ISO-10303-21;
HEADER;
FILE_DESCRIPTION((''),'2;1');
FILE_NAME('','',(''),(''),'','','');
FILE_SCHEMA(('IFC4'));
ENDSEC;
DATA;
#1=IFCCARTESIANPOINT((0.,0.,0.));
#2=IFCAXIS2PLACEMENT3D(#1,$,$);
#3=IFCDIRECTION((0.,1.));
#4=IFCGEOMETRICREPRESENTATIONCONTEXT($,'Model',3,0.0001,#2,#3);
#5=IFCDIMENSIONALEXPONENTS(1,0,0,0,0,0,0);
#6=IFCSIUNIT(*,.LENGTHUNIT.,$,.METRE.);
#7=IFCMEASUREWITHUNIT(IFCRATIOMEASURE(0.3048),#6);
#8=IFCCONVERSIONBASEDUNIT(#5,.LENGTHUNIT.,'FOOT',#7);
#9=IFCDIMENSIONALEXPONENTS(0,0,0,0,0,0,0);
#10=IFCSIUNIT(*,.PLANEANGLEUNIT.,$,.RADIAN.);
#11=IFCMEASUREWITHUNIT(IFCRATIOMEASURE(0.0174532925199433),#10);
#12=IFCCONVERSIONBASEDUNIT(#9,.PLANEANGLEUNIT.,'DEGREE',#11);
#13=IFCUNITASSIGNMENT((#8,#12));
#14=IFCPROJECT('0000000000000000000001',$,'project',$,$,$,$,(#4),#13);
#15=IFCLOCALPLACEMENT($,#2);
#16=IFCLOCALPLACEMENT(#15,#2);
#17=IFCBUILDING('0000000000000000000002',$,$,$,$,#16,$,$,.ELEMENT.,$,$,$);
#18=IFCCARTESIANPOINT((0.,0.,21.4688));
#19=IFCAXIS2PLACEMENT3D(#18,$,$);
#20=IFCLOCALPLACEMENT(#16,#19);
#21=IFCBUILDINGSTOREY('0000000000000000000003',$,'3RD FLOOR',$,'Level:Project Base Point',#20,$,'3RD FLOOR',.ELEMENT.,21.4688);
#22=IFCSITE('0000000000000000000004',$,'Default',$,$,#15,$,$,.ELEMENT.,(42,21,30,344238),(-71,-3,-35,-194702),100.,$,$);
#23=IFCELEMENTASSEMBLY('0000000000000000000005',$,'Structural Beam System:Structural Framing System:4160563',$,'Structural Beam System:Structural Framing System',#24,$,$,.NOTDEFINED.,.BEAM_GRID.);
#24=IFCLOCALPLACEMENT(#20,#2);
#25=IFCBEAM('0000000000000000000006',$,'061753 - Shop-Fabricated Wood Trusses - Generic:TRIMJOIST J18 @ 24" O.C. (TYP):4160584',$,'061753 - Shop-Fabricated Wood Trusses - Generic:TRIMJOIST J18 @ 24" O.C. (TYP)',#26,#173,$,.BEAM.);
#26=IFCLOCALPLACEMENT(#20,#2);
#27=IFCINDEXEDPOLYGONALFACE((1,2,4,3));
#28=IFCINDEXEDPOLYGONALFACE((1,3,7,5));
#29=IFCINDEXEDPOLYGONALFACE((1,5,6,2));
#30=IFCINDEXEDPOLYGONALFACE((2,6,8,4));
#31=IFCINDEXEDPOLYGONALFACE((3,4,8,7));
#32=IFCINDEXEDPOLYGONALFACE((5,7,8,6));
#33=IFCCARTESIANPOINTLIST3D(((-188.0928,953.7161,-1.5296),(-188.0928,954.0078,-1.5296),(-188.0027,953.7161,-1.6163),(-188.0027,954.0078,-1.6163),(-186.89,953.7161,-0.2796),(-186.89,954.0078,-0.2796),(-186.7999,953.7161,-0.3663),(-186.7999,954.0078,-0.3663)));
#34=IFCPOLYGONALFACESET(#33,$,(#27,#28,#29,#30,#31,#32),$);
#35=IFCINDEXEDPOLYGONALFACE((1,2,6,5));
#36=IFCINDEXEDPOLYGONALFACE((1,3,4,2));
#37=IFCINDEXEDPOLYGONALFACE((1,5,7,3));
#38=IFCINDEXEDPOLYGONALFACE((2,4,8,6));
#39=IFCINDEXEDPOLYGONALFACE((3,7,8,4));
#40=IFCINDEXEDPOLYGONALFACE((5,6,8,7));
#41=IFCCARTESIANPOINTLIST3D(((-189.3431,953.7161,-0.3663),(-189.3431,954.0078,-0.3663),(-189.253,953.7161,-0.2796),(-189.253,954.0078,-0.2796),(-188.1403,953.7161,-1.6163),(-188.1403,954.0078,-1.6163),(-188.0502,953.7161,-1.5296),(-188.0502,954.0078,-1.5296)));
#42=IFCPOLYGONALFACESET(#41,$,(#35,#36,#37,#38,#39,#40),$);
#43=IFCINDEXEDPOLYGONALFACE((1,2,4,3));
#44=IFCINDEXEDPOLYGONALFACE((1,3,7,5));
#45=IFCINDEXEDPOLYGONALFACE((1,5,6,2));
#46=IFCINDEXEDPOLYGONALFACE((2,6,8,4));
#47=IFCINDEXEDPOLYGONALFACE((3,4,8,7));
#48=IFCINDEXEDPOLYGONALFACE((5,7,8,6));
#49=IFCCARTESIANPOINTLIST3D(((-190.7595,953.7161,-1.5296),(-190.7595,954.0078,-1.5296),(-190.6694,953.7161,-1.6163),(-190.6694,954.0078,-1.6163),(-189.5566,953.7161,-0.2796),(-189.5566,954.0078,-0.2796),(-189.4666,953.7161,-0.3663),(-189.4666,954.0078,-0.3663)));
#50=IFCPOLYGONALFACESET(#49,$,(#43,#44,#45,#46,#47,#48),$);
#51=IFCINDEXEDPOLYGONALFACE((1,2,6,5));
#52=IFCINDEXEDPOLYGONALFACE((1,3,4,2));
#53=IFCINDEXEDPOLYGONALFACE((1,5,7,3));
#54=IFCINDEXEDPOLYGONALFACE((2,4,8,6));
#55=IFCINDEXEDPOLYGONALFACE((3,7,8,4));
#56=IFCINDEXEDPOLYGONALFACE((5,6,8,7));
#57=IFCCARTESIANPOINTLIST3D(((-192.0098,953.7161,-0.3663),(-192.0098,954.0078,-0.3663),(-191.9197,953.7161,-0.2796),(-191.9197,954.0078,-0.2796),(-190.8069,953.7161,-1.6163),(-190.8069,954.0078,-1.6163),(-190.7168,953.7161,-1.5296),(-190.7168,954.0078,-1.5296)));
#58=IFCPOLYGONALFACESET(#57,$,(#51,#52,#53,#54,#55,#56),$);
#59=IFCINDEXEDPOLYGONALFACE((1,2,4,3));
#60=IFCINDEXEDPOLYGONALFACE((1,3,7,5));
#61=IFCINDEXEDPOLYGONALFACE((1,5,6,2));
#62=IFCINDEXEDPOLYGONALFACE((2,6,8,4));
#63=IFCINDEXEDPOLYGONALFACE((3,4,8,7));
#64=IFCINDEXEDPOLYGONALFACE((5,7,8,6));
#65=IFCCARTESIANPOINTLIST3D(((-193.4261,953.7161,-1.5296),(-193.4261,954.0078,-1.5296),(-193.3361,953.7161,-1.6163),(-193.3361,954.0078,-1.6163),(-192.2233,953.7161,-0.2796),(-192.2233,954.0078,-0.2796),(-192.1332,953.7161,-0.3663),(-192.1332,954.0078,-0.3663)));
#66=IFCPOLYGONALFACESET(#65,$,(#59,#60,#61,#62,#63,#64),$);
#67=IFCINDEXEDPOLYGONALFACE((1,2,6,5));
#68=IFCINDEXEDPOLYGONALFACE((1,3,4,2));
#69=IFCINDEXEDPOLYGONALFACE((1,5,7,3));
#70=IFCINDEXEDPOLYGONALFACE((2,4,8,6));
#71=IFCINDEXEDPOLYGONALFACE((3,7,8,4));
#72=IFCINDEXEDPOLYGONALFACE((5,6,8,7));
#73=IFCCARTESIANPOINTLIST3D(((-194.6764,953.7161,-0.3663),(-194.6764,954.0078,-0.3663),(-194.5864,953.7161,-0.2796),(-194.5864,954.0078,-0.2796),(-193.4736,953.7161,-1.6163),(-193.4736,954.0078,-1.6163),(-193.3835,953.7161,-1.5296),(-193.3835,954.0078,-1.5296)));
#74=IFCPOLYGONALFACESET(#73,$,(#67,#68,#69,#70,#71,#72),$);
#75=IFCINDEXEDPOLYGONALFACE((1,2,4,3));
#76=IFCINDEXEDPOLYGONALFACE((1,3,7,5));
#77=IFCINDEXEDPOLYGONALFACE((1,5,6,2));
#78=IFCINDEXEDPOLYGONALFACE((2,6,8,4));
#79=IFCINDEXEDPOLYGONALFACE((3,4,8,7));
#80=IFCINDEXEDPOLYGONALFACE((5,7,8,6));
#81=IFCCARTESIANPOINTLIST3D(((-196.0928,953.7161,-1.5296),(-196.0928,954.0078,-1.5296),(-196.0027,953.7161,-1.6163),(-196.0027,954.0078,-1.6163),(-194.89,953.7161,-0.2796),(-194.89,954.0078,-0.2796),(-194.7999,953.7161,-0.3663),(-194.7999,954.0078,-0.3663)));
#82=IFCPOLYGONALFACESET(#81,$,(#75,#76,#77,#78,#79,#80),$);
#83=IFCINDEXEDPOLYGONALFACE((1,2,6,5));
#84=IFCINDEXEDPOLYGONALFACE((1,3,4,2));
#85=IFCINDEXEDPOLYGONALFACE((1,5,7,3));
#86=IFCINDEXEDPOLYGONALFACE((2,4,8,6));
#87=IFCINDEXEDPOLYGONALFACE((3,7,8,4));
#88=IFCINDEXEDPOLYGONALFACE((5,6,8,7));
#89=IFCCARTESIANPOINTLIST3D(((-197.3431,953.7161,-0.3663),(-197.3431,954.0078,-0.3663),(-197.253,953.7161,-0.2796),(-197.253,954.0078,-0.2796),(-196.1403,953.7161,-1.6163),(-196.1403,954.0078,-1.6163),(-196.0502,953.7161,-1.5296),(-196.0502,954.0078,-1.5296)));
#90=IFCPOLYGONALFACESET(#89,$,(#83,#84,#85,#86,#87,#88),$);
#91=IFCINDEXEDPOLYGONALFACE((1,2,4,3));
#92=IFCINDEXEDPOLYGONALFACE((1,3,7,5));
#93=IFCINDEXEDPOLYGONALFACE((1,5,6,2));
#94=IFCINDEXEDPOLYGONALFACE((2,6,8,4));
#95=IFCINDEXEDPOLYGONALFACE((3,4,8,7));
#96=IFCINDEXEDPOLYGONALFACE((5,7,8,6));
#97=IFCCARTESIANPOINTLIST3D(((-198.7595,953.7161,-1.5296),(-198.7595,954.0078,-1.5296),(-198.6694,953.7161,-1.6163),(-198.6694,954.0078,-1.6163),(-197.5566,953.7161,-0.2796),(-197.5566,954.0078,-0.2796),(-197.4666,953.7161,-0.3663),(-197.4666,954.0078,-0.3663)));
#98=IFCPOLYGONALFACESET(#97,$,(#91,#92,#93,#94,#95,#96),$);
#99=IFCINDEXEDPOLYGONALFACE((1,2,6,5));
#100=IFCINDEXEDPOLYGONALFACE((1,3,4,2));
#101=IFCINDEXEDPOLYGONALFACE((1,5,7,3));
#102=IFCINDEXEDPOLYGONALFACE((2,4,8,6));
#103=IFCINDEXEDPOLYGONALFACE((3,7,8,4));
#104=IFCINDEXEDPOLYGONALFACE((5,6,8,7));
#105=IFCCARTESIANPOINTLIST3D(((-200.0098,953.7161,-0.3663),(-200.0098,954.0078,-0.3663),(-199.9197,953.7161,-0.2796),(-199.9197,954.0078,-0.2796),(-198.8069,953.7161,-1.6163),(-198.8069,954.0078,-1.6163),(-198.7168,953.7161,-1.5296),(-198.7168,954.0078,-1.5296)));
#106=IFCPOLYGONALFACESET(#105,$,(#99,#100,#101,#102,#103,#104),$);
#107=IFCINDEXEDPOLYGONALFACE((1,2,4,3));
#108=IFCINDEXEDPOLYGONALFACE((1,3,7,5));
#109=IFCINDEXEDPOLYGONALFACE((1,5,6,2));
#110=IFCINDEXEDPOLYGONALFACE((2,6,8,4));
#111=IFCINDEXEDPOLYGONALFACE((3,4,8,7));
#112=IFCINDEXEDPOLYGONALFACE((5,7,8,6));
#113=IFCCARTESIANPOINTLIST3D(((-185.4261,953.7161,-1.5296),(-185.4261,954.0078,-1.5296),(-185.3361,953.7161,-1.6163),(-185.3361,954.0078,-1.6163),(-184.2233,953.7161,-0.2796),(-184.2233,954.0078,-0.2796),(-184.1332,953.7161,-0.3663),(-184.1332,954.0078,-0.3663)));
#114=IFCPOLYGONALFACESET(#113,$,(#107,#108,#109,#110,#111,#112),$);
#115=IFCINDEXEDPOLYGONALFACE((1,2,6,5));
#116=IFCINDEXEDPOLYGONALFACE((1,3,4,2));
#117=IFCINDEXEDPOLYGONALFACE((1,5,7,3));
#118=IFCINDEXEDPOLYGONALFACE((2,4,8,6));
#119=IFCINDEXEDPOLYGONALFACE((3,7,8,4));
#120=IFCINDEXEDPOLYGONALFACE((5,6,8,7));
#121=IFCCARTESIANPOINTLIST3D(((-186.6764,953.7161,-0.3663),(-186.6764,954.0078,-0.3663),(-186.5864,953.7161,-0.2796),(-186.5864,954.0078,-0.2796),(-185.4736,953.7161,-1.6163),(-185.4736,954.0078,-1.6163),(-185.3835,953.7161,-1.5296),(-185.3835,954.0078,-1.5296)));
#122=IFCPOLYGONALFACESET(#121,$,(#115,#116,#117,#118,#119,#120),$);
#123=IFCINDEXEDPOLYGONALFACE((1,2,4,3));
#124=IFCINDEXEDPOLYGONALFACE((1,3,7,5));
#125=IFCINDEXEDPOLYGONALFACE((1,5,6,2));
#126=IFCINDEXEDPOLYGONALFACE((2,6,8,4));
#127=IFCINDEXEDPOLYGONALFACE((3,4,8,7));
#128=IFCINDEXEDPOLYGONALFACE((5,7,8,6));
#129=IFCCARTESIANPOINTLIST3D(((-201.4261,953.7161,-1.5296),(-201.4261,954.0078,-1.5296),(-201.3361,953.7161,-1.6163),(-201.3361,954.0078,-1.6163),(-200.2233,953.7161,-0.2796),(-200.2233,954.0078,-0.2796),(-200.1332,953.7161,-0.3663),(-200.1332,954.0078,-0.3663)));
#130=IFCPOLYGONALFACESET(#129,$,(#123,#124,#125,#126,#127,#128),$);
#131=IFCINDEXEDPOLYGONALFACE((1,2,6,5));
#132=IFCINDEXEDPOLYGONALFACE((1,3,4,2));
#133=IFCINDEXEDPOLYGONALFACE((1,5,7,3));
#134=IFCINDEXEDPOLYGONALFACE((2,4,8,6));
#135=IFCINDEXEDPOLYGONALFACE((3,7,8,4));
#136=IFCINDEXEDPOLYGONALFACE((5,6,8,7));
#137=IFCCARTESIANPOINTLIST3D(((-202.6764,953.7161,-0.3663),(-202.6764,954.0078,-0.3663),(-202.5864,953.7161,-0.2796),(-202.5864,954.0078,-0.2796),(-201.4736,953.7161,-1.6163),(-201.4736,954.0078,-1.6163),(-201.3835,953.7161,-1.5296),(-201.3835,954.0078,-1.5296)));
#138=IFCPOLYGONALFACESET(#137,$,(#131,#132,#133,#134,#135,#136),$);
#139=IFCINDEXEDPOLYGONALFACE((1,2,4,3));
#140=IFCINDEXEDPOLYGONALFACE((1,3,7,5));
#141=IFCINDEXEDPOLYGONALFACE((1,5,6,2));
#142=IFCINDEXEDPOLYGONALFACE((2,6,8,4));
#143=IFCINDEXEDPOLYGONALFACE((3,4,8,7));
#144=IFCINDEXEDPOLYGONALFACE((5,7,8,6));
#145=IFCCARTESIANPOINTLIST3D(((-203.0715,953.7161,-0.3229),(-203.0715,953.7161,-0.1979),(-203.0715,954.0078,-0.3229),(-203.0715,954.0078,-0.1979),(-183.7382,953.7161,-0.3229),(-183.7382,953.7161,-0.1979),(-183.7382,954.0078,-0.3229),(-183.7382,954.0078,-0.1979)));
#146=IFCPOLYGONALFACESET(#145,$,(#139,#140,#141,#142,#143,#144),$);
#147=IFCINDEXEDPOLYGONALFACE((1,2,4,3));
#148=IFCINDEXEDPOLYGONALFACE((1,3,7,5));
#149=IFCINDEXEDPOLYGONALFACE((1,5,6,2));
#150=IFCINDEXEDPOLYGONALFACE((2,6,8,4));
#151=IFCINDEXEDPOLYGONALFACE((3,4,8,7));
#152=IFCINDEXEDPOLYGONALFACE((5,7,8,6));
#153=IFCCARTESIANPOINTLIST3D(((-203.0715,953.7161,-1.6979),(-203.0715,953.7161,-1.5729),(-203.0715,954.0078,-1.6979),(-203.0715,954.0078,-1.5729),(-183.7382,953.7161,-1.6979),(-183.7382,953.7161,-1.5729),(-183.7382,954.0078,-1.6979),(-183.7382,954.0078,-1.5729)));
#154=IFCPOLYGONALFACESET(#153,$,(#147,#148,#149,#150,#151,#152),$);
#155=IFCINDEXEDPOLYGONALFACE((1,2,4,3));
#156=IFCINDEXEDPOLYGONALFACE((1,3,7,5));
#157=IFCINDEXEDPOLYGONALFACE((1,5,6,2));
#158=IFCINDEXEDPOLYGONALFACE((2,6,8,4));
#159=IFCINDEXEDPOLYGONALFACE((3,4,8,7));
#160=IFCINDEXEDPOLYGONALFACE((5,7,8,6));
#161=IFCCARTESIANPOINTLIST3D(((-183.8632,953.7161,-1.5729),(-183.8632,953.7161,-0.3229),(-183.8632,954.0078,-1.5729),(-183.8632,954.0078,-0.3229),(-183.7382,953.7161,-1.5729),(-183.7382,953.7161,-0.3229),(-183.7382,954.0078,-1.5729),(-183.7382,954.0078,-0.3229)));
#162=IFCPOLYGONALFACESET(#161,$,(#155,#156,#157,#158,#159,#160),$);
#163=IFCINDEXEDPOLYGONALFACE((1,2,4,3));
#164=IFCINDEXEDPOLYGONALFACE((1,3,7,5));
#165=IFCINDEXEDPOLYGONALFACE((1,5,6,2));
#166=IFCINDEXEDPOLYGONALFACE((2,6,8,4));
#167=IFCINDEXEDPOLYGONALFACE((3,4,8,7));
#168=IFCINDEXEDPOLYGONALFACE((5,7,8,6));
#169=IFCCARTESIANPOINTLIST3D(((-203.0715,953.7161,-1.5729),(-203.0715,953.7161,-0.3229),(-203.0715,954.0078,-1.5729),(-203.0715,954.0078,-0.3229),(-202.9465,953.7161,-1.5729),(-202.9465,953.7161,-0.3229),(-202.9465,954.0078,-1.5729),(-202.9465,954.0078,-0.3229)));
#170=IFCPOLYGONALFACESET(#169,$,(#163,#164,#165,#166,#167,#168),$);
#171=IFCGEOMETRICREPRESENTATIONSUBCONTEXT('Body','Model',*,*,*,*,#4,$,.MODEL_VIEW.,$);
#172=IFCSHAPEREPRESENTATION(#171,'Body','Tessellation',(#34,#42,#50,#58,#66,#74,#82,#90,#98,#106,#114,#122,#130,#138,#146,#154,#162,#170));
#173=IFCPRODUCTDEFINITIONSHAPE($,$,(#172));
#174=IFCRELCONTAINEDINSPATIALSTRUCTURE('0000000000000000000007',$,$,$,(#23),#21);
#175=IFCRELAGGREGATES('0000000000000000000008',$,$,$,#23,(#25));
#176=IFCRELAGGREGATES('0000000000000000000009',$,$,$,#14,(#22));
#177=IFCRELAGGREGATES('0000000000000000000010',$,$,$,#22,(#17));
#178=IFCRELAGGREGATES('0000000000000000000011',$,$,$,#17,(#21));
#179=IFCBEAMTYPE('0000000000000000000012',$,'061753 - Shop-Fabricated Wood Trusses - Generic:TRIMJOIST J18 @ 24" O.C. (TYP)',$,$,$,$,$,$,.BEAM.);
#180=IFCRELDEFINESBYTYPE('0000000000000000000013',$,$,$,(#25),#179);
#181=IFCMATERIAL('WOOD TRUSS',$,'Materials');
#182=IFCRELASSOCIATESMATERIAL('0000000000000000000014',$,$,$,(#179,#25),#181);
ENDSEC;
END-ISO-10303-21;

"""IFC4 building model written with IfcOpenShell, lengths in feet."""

from ifc_helpers import new_model, entity, si_unit, converted_unit, direction, frame, frame_2d, origin, origin_2d_with_axis, place, context, subcontext, project, spatial, rectangle, extrude, source, transform, mapped, material, material_profile, profile_set, profile_usage, type_object, type_shapes, element, aggregate, save


model = new_model("IFC4")

# Units and contexts
model_context = context("Model", 3, precision=0.0001, world=origin(), true_north=direction((0.0, 1.0)))
body_context = subcontext(model_context, "Body", "Model", "MODEL_VIEW")
ifc_project = project(units=[converted_unit("LENGTHUNIT", "FOOT", entity("IfcRatioMeasure", 0.3048), si_unit("LENGTHUNIT", "METRE"), dimensions=[1, 0, 0, 0, 0, 0, 0]), converted_unit("PLANEANGLEUNIT", "DEGREE", entity("IfcRatioMeasure", 0.0174532925199433), si_unit("PLANEANGLEUNIT", "RADIAN"), dimensions=[0, 0, 0, 0, 0, 0, 0])], contexts=[model_context])

# Site, building, storey
site_placement = place(None, origin())
site = spatial("IfcSite", under=ifc_project, at=site_placement, Name="Default", CompositionType="ELEMENT", RefLatitude=(42, 21, 30, 344238), RefLongitude=(-71, -3, -35, -194702), RefElevation=100.0)
building_placement = place(site_placement, origin())
building = spatial("IfcBuilding", under=site, at=building_placement, CompositionType="ELEMENT")
storey_placement = place(building_placement, frame((0.0, 0.0, 21.4688)))
storey = spatial("IfcBuildingStorey", under=building, at=storey_placement, Name="3RD FLOOR", ObjectType="Level:Project Base Point", LongName="3RD FLOOR", CompositionType="ELEMENT", Elevation=21.4688)

# Shared definitions
ifc_material_1 = material(Name="WOOD TRUSS", Category="Materials")
ifc_material_profile_1 = material_profile(ifc_material_1, rectangle(XDim=1.7347, YDim=0.125, at=frame_2d((0.0, 0.0), x_axis=(1.0, 0.0))), Name="TRIMJOIST J18 @ 24\" O.C. (TYP)")
ifc_material_profile_2 = material_profile(ifc_material_1, rectangle(XDim=1.7347, YDim=0.125, at=frame_2d((0.0, 0.0), x_axis=(1.0, 0.0))), Name="TRIMJOIST J18 @ 24\" O.C. (TYP)")
ifc_material_profile_3 = material_profile(ifc_material_1, rectangle(XDim=1.7347, YDim=0.125, at=frame_2d((0.0, 0.0), x_axis=(1.0, 0.0))), Name="TRIMJOIST J18 @ 24\" O.C. (TYP)")
ifc_material_profile_4 = material_profile(ifc_material_1, rectangle(XDim=1.7347, YDim=0.125, at=frame_2d((0.0, 0.0), x_axis=(1.0, 0.0))), Name="TRIMJOIST J18 @ 24\" O.C. (TYP)")
ifc_material_profile_5 = material_profile(ifc_material_1, rectangle(XDim=1.7347, YDim=0.125, at=frame_2d((0.0, 0.0), x_axis=(1.0, 0.0))), Name="TRIMJOIST J18 @ 24\" O.C. (TYP)")
ifc_material_profile_6 = material_profile(ifc_material_1, rectangle(XDim=1.7347, YDim=0.125, at=frame_2d((0.0, 0.0), x_axis=(1.0, 0.0))), Name="TRIMJOIST J18 @ 24\" O.C. (TYP)")
ifc_material_profile_7 = material_profile(ifc_material_1, rectangle(XDim=1.7347, YDim=0.125, at=frame_2d((0.0, 0.0), x_axis=(1.0, 0.0))), Name="TRIMJOIST J18 @ 24\" O.C. (TYP)")
ifc_material_profile_8 = material_profile(ifc_material_1, rectangle(XDim=1.7347, YDim=0.125, at=frame_2d((0.0, 0.0), x_axis=(1.0, 0.0))), Name="TRIMJOIST J18 @ 24\" O.C. (TYP)")
ifc_material_profile_9 = material_profile(ifc_material_1, rectangle(XDim=1.7347, YDim=0.125, at=frame_2d((0.0, 0.0), x_axis=(1.0, 0.0))), Name="TRIMJOIST J18 @ 24\" O.C. (TYP)")
ifc_material_profile_10 = material_profile(ifc_material_1, rectangle(XDim=1.7347, YDim=0.125, at=origin_2d_with_axis()), Name="TRIMJOIST J18 @ 24\" O.C. (TYP)")
ifc_material_profile_11 = material_profile(ifc_material_1, rectangle(XDim=0.125, YDim=0.2917, at=origin_2d_with_axis()), Name="TRIMJOIST J18 @ 24\" O.C. (TYP)")
ifc_material_profile_12 = material_profile(ifc_material_1, rectangle(XDim=0.125, YDim=0.2917, at=origin_2d_with_axis()), Name="TRIMJOIST J18 @ 24\" O.C. (TYP)")
ifc_material_profile_13 = material_profile(ifc_material_1, rectangle(XDim=1.25, YDim=0.2917, at=origin_2d_with_axis()), Name="TRIMJOIST J18 @ 24\" O.C. (TYP)")
ifc_material_profile_14 = material_profile(ifc_material_1, rectangle(XDim=1.25, YDim=0.2917, at=origin_2d_with_axis()), Name="TRIMJOIST J18 @ 24\" O.C. (TYP)")
ifc_profile_set_1 = profile_set([ifc_material_profile_1, ifc_material_profile_2, ifc_material_profile_3, ifc_material_profile_4, ifc_material_profile_5, ifc_material_profile_6, ifc_material_profile_7, ifc_material_profile_8, ifc_material_profile_9, ifc_material_profile_10, ifc_material_profile_11, ifc_material_profile_12, ifc_material_profile_13, ifc_material_profile_14], Name="TRIMJOIST J18 @ 24\" O.C. (TYP)")

# Element assembly, beam
assembly_1_placement = place(storey_placement, origin())
assembly_1 = element("IfcElementAssembly", 1, at=assembly_1_placement, inside=storey, Name="Structural Beam System:Structural Framing System:4160563", ObjectType="Structural Beam System:Structural Framing System", AssemblyPlace="NOTDEFINED", PredefinedType="BEAM_GRID")
ifc_profile_usage_1 = profile_usage(ifc_profile_set_1, cardinal=8)
beam_type_1 = type_object("IfcBeamType", Name="061753 - Shop-Fabricated Wood Trusses - Generic:TRIMJOIST J18 @ 24\" O.C. (TYP)", PredefinedType="BEAM", material=ifc_profile_set_1)
shared_shape_1 = source(origin(), body_context, "Body", "SweptSolid", [
    extrude(rectangle(XDim=1.7347, YDim=0.125, at=frame_2d((0.0, 0.0), x_axis=(1.0, 0.0))), frame((5.9585, -0.1458, 0.0), z_axis=(0.0, 1.0, 0.0), x_axis=(0.693383, 0.0, 0.720569)), (0.0, 0.0, 1.0), 0.2917),
    extrude(rectangle(XDim=1.7347, YDim=0.125, at=origin_2d_with_axis()), frame((4.7082, -0.1458, 0.0), z_axis=(0.0, 1.0, 0.0), x_axis=(0.693383, 0.0, -0.720569)), (0.0, 0.0, 1.0), 0.2917),
    extrude(rectangle(XDim=1.7347, YDim=0.125, at=frame_2d((0.0, 0.0), x_axis=(1.0, 0.0))), frame((3.2918, -0.1458, 0.0), z_axis=(0.0, 1.0, 0.0), x_axis=(0.693383, 0.0, 0.720569)), (0.0, 0.0, 1.0), 0.2917),
    extrude(rectangle(XDim=1.7347, YDim=0.125, at=frame_2d((0.0, 0.0), x_axis=(1.0, 0.0))), frame((2.0415, -0.1458, 0.0), z_axis=(0.0, 1.0, 0.0), x_axis=(0.693383, 0.0, -0.720569)), (0.0, 0.0, 1.0), 0.2917),
    extrude(rectangle(XDim=1.7347, YDim=0.125, at=frame_2d((0.0, 0.0), x_axis=(1.0, 0.0))), frame((0.6251, -0.1458, 0.0), z_axis=(0.0, 1.0, 0.0), x_axis=(0.693383, 0.0, 0.720569)), (0.0, 0.0, 1.0), 0.2917),
    extrude(rectangle(XDim=1.7347, YDim=0.125, at=frame_2d((0.0, 0.0), x_axis=(1.0, 0.0))), frame((-0.6251, -0.1458, 0.0), z_axis=(0.0, 1.0, 0.0), x_axis=(0.693383, 0.0, -0.720569)), (0.0, 0.0, 1.0), 0.2917),
    extrude(rectangle(XDim=1.7347, YDim=0.125, at=frame_2d((0.0, 0.0), x_axis=(1.0, 0.0))), frame((-2.0415, -0.1458, 0.0), z_axis=(0.0, 1.0, 0.0), x_axis=(0.693383, 0.0, 0.720569)), (0.0, 0.0, 1.0), 0.2917),
    extrude(rectangle(XDim=1.7347, YDim=0.125, at=origin_2d_with_axis()), frame((-3.2918, -0.1458, 0.0), z_axis=(0.0, 1.0, 0.0), x_axis=(0.693383, 0.0, -0.720569)), (0.0, 0.0, 1.0), 0.2917),
    extrude(rectangle(XDim=1.7347, YDim=0.125, at=frame_2d((0.0, 0.0), x_axis=(1.0, 0.0))), frame((-4.7082, -0.1458, 0.0), z_axis=(0.0, 1.0, 0.0), x_axis=(0.693383, 0.0, 0.720569)), (0.0, 0.0, 1.0), 0.2917),
    extrude(rectangle(XDim=1.7347, YDim=0.125, at=frame_2d((0.0, 0.0), x_axis=(1.0, 0.0))), frame((-5.9585, -0.1458, 0.0), z_axis=(0.0, 1.0, 0.0), x_axis=(0.693383, 0.0, -0.720569)), (0.0, 0.0, 1.0), 0.2917),
    extrude(rectangle(XDim=1.7347, YDim=0.125, at=frame_2d((0.0, 0.0), x_axis=(1.0, 0.0))), frame((8.6251, -0.1458, 0.0), z_axis=(0.0, 1.0, 0.0), x_axis=(0.693383, 0.0, 0.720569)), (0.0, 0.0, 1.0), 0.2917),
    extrude(rectangle(XDim=1.7347, YDim=0.125, at=origin_2d_with_axis()), frame((7.3749, -0.1458, 0.0), z_axis=(0.0, 1.0, 0.0), x_axis=(0.693383, 0.0, -0.720569)), (0.0, 0.0, 1.0), 0.2917),
    extrude(rectangle(XDim=1.7347, YDim=0.125, at=frame_2d((0.0, 0.0), x_axis=(1.0, 0.0))), frame((-7.3749, -0.1458, 0.0), z_axis=(0.0, 1.0, 0.0), x_axis=(0.693383, 0.0, 0.720569)), (0.0, 0.0, 1.0), 0.2917),
    extrude(rectangle(XDim=1.7347, YDim=0.125, at=origin_2d_with_axis()), frame((-8.6251, -0.1458, 0.0), z_axis=(0.0, 1.0, 0.0), x_axis=(0.693383, 0.0, -0.720569)), (0.0, 0.0, 1.0), 0.2917),
    extrude(rectangle(XDim=0.125, YDim=0.2917, at=origin_2d_with_axis()), frame((-9.6667, 0.0, 0.6875), z_axis=(1.0, 0.0, 0.0), x_axis=(0.0, 0.0, -1.0)), (0.0, 0.0, 1.0), 19.3333),
    extrude(rectangle(XDim=0.125, YDim=0.2917, at=origin_2d_with_axis()), frame((-9.6667, 0.0, -0.6875), z_axis=(1.0, 0.0, 0.0), x_axis=(0.0, 0.0, -1.0)), (0.0, 0.0, 1.0), 19.3333),
    extrude(rectangle(XDim=1.25, YDim=0.2917, at=origin_2d_with_axis()), frame((9.5417, 0.0, 0.0), z_axis=(1.0, 0.0, 0.0), x_axis=(0.0, 0.0, -1.0)), (0.0, 0.0, 1.0), 0.125),
    extrude(rectangle(XDim=1.25, YDim=0.2917, at=origin_2d_with_axis()), frame((-9.6667, 0.0, 0.0), z_axis=(1.0, 0.0, 0.0), x_axis=(0.0, 0.0, -1.0)), (0.0, 0.0, 1.0), 0.125),
])
type_shapes(beam_type_1, [shared_shape_1])
beam_1_placement = place(assembly_1_placement, frame((-193.4048, 953.8619, -0.9479)))
beam_1 = element("IfcBeam", 2, at=beam_1_placement, type_object=beam_type_1, material=ifc_profile_usage_1, Name="061753 - Shop-Fabricated Wood Trusses - Generic:TRIMJOIST J18 @ 24\" O.C. (TYP):4160584", ObjectType="061753 - Shop-Fabricated Wood Trusses - Generic:TRIMJOIST J18 @ 24\" O.C. (TYP)", PredefinedType="BEAM", context=body_context, shape_type="MappedRepresentation", body=[
    mapped(shared_shape_1, transform((0.0, 0.0, 0.0), scale=1.0)),
])

aggregate(assembly_1, [beam_1])

save(model, "model.ifc")
